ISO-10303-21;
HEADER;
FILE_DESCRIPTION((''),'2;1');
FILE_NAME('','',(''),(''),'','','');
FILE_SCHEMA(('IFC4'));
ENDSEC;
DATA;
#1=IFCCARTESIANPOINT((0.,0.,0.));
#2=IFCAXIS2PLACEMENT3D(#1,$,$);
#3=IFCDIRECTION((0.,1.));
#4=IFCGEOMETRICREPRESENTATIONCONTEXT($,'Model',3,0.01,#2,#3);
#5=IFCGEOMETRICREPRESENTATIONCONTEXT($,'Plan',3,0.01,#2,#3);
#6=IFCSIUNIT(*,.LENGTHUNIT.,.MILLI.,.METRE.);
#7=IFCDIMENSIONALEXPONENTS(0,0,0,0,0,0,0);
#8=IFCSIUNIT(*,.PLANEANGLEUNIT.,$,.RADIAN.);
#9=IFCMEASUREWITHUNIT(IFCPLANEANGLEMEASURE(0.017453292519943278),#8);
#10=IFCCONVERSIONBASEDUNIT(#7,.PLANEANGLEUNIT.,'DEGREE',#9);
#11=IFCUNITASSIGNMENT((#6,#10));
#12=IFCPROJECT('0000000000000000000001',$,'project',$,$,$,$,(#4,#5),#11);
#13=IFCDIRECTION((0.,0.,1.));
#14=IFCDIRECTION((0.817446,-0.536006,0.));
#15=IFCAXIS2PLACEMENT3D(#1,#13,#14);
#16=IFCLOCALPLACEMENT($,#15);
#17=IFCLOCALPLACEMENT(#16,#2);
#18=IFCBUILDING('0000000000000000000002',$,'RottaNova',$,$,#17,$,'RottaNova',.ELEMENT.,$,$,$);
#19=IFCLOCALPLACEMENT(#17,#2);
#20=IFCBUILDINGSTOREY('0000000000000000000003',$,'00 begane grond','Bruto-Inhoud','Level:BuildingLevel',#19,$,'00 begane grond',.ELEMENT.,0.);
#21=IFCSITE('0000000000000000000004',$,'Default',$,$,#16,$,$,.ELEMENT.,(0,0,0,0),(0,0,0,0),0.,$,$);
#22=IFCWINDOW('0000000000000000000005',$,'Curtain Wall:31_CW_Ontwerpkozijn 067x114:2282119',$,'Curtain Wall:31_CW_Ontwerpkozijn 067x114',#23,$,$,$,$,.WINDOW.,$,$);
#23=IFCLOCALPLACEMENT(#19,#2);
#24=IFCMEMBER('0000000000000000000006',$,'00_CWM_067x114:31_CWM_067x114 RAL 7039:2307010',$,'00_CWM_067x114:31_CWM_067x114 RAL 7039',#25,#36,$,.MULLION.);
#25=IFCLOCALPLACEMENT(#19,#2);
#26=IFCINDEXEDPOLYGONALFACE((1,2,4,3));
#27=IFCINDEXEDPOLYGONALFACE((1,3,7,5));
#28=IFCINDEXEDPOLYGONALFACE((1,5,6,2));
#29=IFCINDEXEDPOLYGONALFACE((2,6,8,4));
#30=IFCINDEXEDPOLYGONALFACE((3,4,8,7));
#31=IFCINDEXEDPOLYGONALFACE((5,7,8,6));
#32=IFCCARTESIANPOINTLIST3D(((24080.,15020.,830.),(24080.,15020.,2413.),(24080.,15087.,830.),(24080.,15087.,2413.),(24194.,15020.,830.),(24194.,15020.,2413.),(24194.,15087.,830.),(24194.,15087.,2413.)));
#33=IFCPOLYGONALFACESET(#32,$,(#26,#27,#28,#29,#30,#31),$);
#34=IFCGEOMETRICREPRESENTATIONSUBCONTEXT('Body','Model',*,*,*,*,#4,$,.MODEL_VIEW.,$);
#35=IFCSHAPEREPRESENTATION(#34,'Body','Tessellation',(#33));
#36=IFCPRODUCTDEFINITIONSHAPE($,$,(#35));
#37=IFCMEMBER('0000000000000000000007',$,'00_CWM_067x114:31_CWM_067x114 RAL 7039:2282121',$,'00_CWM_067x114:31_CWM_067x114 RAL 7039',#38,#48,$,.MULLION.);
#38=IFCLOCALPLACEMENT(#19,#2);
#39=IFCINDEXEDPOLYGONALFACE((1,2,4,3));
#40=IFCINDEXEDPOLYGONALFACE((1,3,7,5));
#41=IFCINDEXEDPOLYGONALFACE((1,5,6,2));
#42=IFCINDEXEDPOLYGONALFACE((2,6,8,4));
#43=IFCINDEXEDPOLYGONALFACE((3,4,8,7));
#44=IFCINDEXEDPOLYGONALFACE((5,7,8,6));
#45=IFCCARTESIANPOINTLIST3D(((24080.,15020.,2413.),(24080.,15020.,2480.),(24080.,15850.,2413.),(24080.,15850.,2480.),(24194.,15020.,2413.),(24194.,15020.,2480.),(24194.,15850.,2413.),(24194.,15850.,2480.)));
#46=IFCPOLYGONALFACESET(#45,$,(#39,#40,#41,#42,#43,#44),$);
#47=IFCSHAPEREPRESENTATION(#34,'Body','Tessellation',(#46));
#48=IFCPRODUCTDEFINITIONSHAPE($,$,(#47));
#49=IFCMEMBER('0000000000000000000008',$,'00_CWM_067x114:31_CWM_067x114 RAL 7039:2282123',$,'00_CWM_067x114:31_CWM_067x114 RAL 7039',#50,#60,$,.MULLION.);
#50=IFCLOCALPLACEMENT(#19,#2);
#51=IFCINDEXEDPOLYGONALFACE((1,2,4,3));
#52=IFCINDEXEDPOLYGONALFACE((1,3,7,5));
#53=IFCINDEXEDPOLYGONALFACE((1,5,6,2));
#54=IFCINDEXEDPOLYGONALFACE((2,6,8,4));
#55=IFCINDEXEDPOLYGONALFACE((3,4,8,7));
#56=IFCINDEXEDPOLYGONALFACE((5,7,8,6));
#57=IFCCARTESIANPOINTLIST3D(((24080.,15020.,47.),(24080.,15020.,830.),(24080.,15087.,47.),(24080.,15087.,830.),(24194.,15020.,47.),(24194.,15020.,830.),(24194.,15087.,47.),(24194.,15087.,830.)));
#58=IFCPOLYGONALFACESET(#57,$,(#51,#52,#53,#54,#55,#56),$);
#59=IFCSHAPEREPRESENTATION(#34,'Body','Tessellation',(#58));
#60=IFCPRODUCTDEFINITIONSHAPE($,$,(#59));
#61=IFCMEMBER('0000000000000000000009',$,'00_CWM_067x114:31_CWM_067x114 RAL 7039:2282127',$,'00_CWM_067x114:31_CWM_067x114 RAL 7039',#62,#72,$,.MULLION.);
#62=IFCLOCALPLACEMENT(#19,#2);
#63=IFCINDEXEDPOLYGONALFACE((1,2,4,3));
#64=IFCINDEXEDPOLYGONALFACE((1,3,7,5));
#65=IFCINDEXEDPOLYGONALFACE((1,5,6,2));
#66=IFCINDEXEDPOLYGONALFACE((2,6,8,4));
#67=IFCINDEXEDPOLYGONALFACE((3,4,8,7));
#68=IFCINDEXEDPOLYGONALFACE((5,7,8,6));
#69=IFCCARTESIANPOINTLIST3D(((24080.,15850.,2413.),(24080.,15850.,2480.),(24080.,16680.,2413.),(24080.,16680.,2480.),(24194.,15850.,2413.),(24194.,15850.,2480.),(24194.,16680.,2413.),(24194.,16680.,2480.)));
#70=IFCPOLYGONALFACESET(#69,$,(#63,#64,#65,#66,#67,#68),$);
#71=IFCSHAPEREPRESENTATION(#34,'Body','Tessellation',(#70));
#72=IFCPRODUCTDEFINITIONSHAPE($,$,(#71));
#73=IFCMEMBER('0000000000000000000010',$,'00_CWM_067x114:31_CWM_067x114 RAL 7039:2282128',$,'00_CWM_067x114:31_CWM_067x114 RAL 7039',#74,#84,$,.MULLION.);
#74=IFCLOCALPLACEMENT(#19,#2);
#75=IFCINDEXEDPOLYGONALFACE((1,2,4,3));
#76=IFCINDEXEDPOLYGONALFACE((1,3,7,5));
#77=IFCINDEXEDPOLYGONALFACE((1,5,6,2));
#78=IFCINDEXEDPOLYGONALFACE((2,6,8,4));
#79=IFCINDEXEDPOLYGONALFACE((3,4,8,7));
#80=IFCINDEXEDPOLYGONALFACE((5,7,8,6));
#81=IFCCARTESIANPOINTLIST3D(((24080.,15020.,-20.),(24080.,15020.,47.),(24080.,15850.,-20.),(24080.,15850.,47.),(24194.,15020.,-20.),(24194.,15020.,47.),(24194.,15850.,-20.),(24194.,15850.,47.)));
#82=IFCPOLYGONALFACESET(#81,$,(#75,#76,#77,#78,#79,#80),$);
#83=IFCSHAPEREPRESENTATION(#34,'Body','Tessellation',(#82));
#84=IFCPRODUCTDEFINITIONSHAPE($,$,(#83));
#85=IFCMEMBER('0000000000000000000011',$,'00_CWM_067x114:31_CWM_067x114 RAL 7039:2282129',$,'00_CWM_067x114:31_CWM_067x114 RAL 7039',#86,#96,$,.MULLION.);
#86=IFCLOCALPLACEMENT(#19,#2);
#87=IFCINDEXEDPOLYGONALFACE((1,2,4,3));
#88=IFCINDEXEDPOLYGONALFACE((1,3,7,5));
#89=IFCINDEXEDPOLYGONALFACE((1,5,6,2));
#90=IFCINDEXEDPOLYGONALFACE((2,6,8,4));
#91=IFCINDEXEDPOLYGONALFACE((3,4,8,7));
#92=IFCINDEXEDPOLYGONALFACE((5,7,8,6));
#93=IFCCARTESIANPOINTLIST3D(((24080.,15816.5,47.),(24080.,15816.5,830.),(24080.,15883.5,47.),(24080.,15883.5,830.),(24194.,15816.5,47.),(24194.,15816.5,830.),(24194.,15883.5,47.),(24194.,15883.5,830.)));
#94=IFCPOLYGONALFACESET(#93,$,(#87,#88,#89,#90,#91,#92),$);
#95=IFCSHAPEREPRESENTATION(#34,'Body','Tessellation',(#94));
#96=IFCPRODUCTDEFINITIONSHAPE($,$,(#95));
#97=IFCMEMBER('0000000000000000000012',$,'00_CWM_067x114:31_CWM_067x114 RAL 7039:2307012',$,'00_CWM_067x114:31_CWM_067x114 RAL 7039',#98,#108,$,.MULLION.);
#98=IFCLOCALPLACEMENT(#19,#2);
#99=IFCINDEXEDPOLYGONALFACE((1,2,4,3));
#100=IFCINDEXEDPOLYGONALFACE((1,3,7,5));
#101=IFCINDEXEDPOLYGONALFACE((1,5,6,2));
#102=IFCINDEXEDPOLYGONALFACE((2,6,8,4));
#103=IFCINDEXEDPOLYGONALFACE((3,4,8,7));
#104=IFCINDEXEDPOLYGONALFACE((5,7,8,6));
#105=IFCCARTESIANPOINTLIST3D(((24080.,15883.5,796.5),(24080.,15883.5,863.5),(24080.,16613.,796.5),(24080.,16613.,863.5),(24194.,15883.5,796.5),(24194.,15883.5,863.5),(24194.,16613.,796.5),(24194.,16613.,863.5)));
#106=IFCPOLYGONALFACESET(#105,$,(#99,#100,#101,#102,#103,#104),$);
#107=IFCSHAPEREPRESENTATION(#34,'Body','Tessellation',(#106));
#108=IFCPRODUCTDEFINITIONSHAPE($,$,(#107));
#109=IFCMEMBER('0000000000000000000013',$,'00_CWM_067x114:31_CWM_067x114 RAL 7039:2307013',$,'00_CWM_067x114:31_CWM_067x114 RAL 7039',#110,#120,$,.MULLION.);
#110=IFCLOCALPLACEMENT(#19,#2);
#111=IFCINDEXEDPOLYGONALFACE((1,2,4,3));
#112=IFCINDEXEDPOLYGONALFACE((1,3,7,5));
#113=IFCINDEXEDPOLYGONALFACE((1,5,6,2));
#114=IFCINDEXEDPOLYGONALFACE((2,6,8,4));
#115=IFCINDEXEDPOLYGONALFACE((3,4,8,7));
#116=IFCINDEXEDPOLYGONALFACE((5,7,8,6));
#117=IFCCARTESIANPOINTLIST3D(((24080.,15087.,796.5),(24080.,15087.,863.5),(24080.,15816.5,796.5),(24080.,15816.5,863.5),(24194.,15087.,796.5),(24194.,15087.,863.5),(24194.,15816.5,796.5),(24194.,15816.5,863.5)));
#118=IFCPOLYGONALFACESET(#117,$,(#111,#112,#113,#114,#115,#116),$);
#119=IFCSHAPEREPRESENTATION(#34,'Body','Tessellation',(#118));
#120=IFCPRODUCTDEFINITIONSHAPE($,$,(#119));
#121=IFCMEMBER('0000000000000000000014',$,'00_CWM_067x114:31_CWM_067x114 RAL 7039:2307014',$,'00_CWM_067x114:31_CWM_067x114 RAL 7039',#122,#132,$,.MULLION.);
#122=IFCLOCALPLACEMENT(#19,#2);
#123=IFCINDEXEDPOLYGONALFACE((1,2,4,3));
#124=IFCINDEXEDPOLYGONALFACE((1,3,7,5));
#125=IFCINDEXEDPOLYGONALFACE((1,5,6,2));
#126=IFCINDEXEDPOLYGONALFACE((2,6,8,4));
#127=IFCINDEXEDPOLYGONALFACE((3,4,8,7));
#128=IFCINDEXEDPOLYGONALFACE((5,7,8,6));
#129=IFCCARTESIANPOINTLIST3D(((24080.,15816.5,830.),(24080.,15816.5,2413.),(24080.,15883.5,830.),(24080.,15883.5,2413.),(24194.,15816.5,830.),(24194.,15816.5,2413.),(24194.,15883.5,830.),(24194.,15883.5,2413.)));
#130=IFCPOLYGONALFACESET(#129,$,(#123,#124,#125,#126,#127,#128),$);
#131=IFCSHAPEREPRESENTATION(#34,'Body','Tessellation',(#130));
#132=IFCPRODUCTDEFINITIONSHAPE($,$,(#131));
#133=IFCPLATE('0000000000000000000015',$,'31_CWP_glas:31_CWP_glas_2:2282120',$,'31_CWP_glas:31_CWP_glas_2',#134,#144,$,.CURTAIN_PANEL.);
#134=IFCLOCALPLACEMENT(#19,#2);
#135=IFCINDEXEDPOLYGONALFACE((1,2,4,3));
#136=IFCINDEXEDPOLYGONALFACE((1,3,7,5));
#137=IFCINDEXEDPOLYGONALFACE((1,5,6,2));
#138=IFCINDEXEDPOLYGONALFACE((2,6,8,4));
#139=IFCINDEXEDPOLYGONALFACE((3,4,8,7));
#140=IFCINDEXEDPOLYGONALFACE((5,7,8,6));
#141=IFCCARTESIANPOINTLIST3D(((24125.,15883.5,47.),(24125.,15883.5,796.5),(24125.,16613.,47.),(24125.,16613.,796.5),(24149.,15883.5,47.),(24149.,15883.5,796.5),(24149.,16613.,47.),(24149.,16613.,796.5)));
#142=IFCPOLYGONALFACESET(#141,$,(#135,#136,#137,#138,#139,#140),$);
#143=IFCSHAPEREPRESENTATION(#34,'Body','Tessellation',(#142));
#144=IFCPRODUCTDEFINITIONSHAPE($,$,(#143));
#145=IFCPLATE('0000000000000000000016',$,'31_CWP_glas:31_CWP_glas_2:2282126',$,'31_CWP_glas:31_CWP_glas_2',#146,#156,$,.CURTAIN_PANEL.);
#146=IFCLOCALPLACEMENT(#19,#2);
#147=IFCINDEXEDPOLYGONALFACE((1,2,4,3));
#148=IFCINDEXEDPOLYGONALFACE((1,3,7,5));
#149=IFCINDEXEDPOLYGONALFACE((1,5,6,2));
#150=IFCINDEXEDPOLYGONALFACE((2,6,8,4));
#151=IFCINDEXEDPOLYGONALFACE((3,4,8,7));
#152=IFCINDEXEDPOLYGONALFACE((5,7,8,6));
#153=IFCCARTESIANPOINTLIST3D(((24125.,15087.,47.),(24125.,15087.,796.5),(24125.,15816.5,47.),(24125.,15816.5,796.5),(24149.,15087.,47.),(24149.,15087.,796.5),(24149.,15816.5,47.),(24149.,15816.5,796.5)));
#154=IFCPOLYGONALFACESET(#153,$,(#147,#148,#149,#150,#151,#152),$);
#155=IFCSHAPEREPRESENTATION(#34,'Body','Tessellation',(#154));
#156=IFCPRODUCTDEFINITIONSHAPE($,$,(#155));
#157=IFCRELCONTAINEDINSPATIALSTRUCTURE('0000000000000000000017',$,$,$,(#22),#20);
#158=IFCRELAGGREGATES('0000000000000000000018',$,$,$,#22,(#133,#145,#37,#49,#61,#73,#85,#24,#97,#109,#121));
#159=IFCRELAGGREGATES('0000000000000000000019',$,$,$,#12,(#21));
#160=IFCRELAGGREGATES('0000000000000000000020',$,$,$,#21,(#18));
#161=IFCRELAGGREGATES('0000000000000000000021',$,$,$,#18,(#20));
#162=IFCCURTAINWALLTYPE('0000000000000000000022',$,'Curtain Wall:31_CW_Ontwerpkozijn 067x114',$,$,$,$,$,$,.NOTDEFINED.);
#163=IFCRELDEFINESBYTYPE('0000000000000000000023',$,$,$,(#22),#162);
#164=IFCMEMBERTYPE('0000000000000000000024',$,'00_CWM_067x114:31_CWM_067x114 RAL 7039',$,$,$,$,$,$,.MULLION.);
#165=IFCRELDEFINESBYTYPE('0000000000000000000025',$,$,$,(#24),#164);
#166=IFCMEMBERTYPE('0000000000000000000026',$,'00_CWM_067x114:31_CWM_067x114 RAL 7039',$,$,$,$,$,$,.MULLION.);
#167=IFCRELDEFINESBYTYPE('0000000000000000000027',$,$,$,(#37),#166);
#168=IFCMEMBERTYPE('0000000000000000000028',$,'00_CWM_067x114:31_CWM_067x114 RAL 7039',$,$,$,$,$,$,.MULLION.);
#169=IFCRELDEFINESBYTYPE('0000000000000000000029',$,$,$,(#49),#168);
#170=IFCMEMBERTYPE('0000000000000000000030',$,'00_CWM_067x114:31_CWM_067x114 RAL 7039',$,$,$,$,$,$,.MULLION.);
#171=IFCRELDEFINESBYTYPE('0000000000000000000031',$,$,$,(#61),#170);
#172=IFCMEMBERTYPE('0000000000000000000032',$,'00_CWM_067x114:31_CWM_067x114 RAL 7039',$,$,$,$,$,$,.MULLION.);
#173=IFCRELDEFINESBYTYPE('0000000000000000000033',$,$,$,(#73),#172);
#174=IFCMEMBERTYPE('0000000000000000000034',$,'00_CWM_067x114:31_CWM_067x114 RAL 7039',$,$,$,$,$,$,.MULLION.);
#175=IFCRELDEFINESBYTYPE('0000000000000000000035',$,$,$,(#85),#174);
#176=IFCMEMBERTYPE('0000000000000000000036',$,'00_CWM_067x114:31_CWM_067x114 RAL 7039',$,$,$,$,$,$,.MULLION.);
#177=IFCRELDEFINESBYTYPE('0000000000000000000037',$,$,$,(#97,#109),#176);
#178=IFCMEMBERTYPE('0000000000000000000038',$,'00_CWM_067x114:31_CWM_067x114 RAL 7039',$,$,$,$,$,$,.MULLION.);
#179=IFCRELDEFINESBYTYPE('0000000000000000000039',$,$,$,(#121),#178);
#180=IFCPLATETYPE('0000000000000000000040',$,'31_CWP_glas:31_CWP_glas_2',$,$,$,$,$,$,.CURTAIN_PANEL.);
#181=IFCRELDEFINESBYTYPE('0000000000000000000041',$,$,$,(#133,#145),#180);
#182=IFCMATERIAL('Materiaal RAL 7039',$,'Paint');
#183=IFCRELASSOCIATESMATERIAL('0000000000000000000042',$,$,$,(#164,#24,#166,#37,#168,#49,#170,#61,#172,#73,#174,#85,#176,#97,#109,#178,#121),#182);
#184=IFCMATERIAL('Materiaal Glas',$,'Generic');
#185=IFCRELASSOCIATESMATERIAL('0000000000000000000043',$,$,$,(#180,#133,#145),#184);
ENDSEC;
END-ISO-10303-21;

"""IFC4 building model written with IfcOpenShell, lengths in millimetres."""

from ifc_helpers import new_model, entity, si_unit, converted_unit, direction, frame, origin, place, context, subcontext, project, spatial, indexed_curve, outline, extrude, source, transform, mapped, material, type_object, type_shapes, element, aggregate, save


model = new_model("IFC4")

# Units and contexts
model_context = context("Model", 3, precision=0.01, world=origin(), true_north=direction((0.0, 1.0)))
plan_context = context("Plan", 3, precision=0.01, world=origin(), true_north=direction((0.0, 1.0)))
body_context = subcontext(model_context, "Body", "Model", "MODEL_VIEW")
ifc_project = project(units=[si_unit("LENGTHUNIT", "METRE", prefix="MILLI"), converted_unit("PLANEANGLEUNIT", "DEGREE", entity("IfcPlaneAngleMeasure", 0.017453292519943278), si_unit("PLANEANGLEUNIT", "RADIAN"), dimensions=[0, 0, 0, 0, 0, 0, 0])], contexts=[model_context, plan_context])

# Site, building, storey
site_placement = place(None, frame((0.0, 0.0, 0.0), z_axis=(0.0, 0.0, 1.0), x_axis=(0.817446, -0.536006, 0.0)))
site = spatial("IfcSite", under=ifc_project, at=site_placement, Name="Default", CompositionType="ELEMENT", RefLatitude=(0, 0, 0, 0), RefLongitude=(0, 0, 0, 0), RefElevation=0.0)
building_placement = place(site_placement, origin())
building = spatial("IfcBuilding", under=site, at=building_placement, Name="RottaNova", LongName="RottaNova", CompositionType="ELEMENT")
storey_placement = place(building_placement, origin())
storey = spatial("IfcBuildingStorey", under=building, at=storey_placement, Name="00 begane grond", Description="Bruto-Inhoud", ObjectType="Level:BuildingLevel", LongName="00 begane grond", CompositionType="ELEMENT", Elevation=0.0)

# Window, members, plates
curtain_wall_type = type_object("IfcCurtainWallType", Name="Curtain Wall:31_CW_Ontwerpkozijn 067x114", PredefinedType="NOTDEFINED")
window_placement = place(storey_placement, origin())
window = element("IfcWindow", 1, at=window_placement, inside=storey, type_object=curtain_wall_type, Name="Curtain Wall:31_CW_Ontwerpkozijn 067x114:2282119", ObjectType="Curtain Wall:31_CW_Ontwerpkozijn 067x114", PredefinedType="WINDOW")
ifc_material_1 = material(Name="Materiaal RAL 7039", Category="Paint")
member_type_1 = type_object("IfcMemberType", Name="00_CWM_067x114:31_CWM_067x114 RAL 7039", PredefinedType="MULLION", material=ifc_material_1)
shared_shape_1 = source(origin(), body_context, "Body", "SweptSolid", [
    extrude(outline(indexed_curve([(-33.5, -57.0), (33.5, -57.0), (33.5, 57.0), (-33.5, 57.0), (-33.5, -57.0)], self_intersect=False)), frame((-33.5, -57.0, -1583.0), z_axis=(0.0, 0.0, 1.0), x_axis=(-1.0, 0.0, 0.0)), (0.0, 0.0, 1.0), 1583.0),
])
type_shapes(member_type_1, [shared_shape_1])
member_1_placement = place(window_placement, frame((24080.0, 15020.0, 830.0), z_axis=(0.0, 0.0, -1.0), x_axis=(0.0, -1.0, 0.0)))
member_1 = element("IfcMember", 2, at=member_1_placement, type_object=member_type_1, material=ifc_material_1, Name="00_CWM_067x114:31_CWM_067x114 RAL 7039:2307010", ObjectType="00_CWM_067x114:31_CWM_067x114 RAL 7039", PredefinedType="MULLION", context=body_context, shape_type="MappedRepresentation", body=[
    mapped(shared_shape_1, transform((0.0, 0.0, 0.0), scale=1.0)),
])
member_type_2 = type_object("IfcMemberType", Name="00_CWM_067x114:31_CWM_067x114 RAL 7039", PredefinedType="MULLION", material=ifc_material_1)
shared_shape_2 = source(origin(), body_context, "Body", "SweptSolid", [
    extrude(outline(indexed_curve([(-33.5, -57.0), (33.5, -57.0), (33.5, 57.0), (-33.5, 57.0), (-33.5, -57.0)], self_intersect=False)), frame((-33.5, -57.0, -830.0), z_axis=(0.0, 0.0, 1.0), x_axis=(-1.0, 0.0, 0.0)), (0.0, 0.0, 1.0), 830.0),
])
type_shapes(member_type_2, [shared_shape_2])
member_2_placement = place(window_placement, frame((24080.0, 15020.0, 2480.0), z_axis=(0.0, -1.0, 0.0), x_axis=(0.0, 0.0, 1.0)))
member_2 = element("IfcMember", 3, at=member_2_placement, type_object=member_type_2, material=ifc_material_1, Name="00_CWM_067x114:31_CWM_067x114 RAL 7039:2282121", ObjectType="00_CWM_067x114:31_CWM_067x114 RAL 7039", PredefinedType="MULLION", context=body_context, shape_type="MappedRepresentation", body=[
    mapped(shared_shape_2, transform((0.0, 0.0, 0.0), scale=1.0)),
])
member_type_3 = type_object("IfcMemberType", Name="00_CWM_067x114:31_CWM_067x114 RAL 7039", PredefinedType="MULLION", material=ifc_material_1)
shared_shape_3 = source(origin(), body_context, "Body", "SweptSolid", [
    extrude(outline(indexed_curve([(-33.5, -57.0), (33.5, -57.0), (33.5, 57.0), (-33.5, 57.0), (-33.5, -57.0)], self_intersect=False)), frame((-33.5, -57.0, -783.0), z_axis=(0.0, 0.0, 1.0), x_axis=(-1.0, 0.0, 0.0)), (0.0, 0.0, 1.0), 783.0),
])
type_shapes(member_type_3, [shared_shape_3])
member_3_placement = place(window_placement, frame((24080.0, 15020.0, 47.0), z_axis=(0.0, 0.0, -1.0), x_axis=(0.0, -1.0, 0.0)))
member_3 = element("IfcMember", 4, at=member_3_placement, type_object=member_type_3, material=ifc_material_1, Name="00_CWM_067x114:31_CWM_067x114 RAL 7039:2282123", ObjectType="00_CWM_067x114:31_CWM_067x114 RAL 7039", PredefinedType="MULLION", context=body_context, shape_type="MappedRepresentation", body=[
    mapped(shared_shape_3, transform((0.0, 0.0, 0.0), scale=1.0)),
])
member_type_4 = type_object("IfcMemberType", Name="00_CWM_067x114:31_CWM_067x114 RAL 7039", PredefinedType="MULLION", material=ifc_material_1)
shared_shape_4 = source(origin(), body_context, "Body", "SweptSolid", [
    extrude(outline(indexed_curve([(-33.5, -57.0), (33.5, -57.0), (33.5, 57.0), (-33.5, 57.0), (-33.5, -57.0)], self_intersect=False)), frame((-33.5, -57.0, -830.0), z_axis=(0.0, 0.0, 1.0), x_axis=(-1.0, 0.0, 0.0)), (0.0, 0.0, 1.0), 830.0),
])
type_shapes(member_type_4, [shared_shape_4])
member_4_placement = place(window_placement, frame((24080.0, 15850.0, 2480.0), z_axis=(0.0, -1.0, 0.0), x_axis=(0.0, 0.0, 1.0)))
member_4 = element("IfcMember", 5, at=member_4_placement, type_object=member_type_4, material=ifc_material_1, Name="00_CWM_067x114:31_CWM_067x114 RAL 7039:2282127", ObjectType="00_CWM_067x114:31_CWM_067x114 RAL 7039", PredefinedType="MULLION", context=body_context, shape_type="MappedRepresentation", body=[
    mapped(shared_shape_4, transform((0.0, 0.0, 0.0), scale=1.0)),
])
member_type_5 = type_object("IfcMemberType", Name="00_CWM_067x114:31_CWM_067x114 RAL 7039", PredefinedType="MULLION", material=ifc_material_1)
shared_shape_5 = source(origin(), body_context, "Body", "SweptSolid", [
    extrude(outline(indexed_curve([(-33.5, -57.0), (33.5, -57.0), (33.5, 57.0), (-33.5, 57.0), (-33.5, -57.0)], self_intersect=False)), frame((-33.5, -57.0, -830.0), z_axis=(0.0, 0.0, 1.0), x_axis=(-1.0, 0.0, 0.0)), (0.0, 0.0, 1.0), 830.0),
])
type_shapes(member_type_5, [shared_shape_5])
member_5_placement = place(window_placement, frame((24080.0, 15850.0, -20.0), z_axis=(0.0, 1.0, 0.0), x_axis=(0.0, 0.0, -1.0)))
member_5 = element("IfcMember", 6, at=member_5_placement, type_object=member_type_5, material=ifc_material_1, Name="00_CWM_067x114:31_CWM_067x114 RAL 7039:2282128", ObjectType="00_CWM_067x114:31_CWM_067x114 RAL 7039", PredefinedType="MULLION", context=body_context, shape_type="MappedRepresentation", body=[
    mapped(shared_shape_5, transform((0.0, 0.0, 0.0), scale=1.0)),
])
member_type_6 = type_object("IfcMemberType", Name="00_CWM_067x114:31_CWM_067x114 RAL 7039", PredefinedType="MULLION", material=ifc_material_1)
shared_shape_6 = source(origin(), body_context, "Body", "SweptSolid", [
    extrude(outline(indexed_curve([(-33.5, -57.0), (33.5, -57.0), (33.5, 57.0), (-33.5, 57.0), (-33.5, -57.0)], self_intersect=False)), frame((0.0, -57.0, -783.0), z_axis=(0.0, 0.0, 1.0), x_axis=(-1.0, 0.0, 0.0)), (0.0, 0.0, 1.0), 783.0),
])
type_shapes(member_type_6, [shared_shape_6])
member_6_placement = place(window_placement, frame((24080.0, 15850.0, 47.0), z_axis=(0.0, 0.0, -1.0), x_axis=(0.0, -1.0, 0.0)))
member_6 = element("IfcMember", 7, at=member_6_placement, type_object=member_type_6, material=ifc_material_1, Name="00_CWM_067x114:31_CWM_067x114 RAL 7039:2282129", ObjectType="00_CWM_067x114:31_CWM_067x114 RAL 7039", PredefinedType="MULLION", context=body_context, shape_type="MappedRepresentation", body=[
    mapped(shared_shape_6, transform((0.0, 0.0, 0.0), scale=1.0)),
])
member_type_7 = type_object("IfcMemberType", Name="00_CWM_067x114:31_CWM_067x114 RAL 7039", PredefinedType="MULLION", material=ifc_material_1)
shared_shape_7 = source(origin(), body_context, "Body", "SweptSolid", [
    extrude(outline(indexed_curve([(-33.5, -57.0), (33.5, -57.0), (33.5, 57.0), (-33.5, 57.0), (-33.5, -57.0)], self_intersect=False)), frame((0.0, -57.0, -729.5), z_axis=(0.0, 0.0, 1.0), x_axis=(-1.0, 0.0, 0.0)), (0.0, 0.0, 1.0), 729.5),
])
type_shapes(member_type_7, [shared_shape_7])
member_7_placement = place(window_placement, frame((24080.0, 15883.5, 830.0), z_axis=(0.0, -1.0, 0.0), x_axis=(0.0, 0.0, 1.0)))
member_7 = element("IfcMember", 8, at=member_7_placement, type_object=member_type_7, material=ifc_material_1, Name="00_CWM_067x114:31_CWM_067x114 RAL 7039:2307012", ObjectType="00_CWM_067x114:31_CWM_067x114 RAL 7039", PredefinedType="MULLION", context=body_context, shape_type="MappedRepresentation", body=[
    mapped(shared_shape_7, transform((0.0, 0.0, 0.0), scale=1.0)),
])
member_8_placement = place(window_placement, frame((24080.0, 15087.0, 830.0), z_axis=(0.0, -1.0, 0.0), x_axis=(0.0, 0.0, 1.0)))
member_8 = element("IfcMember", 9, at=member_8_placement, type_object=member_type_7, material=ifc_material_1, Name="00_CWM_067x114:31_CWM_067x114 RAL 7039:2307013", ObjectType="00_CWM_067x114:31_CWM_067x114 RAL 7039", PredefinedType="MULLION", context=body_context, shape_type="MappedRepresentation", body=[
    mapped(shared_shape_7, transform((0.0, 0.0, 0.0), scale=1.0)),
])
member_type_8 = type_object("IfcMemberType", Name="00_CWM_067x114:31_CWM_067x114 RAL 7039", PredefinedType="MULLION", material=ifc_material_1)
shared_shape_8 = source(origin(), body_context, "Body", "SweptSolid", [
    extrude(outline(indexed_curve([(-33.5, -57.0), (33.5, -57.0), (33.5, 57.0), (-33.5, 57.0), (-33.5, -57.0)], self_intersect=False)), frame((0.0, -57.0, -1583.0), z_axis=(0.0, 0.0, 1.0), x_axis=(-1.0, 0.0, 0.0)), (0.0, 0.0, 1.0), 1583.0),
])
type_shapes(member_type_8, [shared_shape_8])
member_9_placement = place(window_placement, frame((24080.0, 15850.0, 830.0), z_axis=(0.0, 0.0, -1.0), x_axis=(0.0, -1.0, 0.0)))
member_9 = element("IfcMember", 10, at=member_9_placement, type_object=member_type_8, material=ifc_material_1, Name="00_CWM_067x114:31_CWM_067x114 RAL 7039:2307014", ObjectType="00_CWM_067x114:31_CWM_067x114 RAL 7039", PredefinedType="MULLION", context=body_context, shape_type="MappedRepresentation", body=[
    mapped(shared_shape_8, transform((0.0, 0.0, 0.0), scale=1.0)),
])
ifc_material_2 = material(Name="Materiaal Glas", Category="Generic")
plate_type_1 = type_object("IfcPlateType", Name="31_CWP_glas:31_CWP_glas_2", PredefinedType="CURTAIN_PANEL", material=ifc_material_2)
shared_shape_9 = source(origin(), body_context, "Body", "SweptSolid", [
    extrude(outline(indexed_curve([(-12.0, -364.7), (12.0, -364.7), (12.0, 364.7), (-12.0, 364.7), (-12.0, -364.7)], self_intersect=False)), frame((0.0, 57.0, 0.0), z_axis=(0.0, 0.0, 1.0), x_axis=(0.0, 1.0, 0.0)), (0.0, 0.0, 1.0), 749.5),
])
type_shapes(plate_type_1, [shared_shape_9])
plate_1_placement = place(window_placement, frame((24080.0, 16248.3, 47.0), z_axis=(0.0, 0.0, 1.0), x_axis=(0.0, -1.0, 0.0)))
plate_1 = element("IfcPlate", 11, at=plate_1_placement, type_object=plate_type_1, material=ifc_material_2, Name="31_CWP_glas:31_CWP_glas_2:2282120", ObjectType="31_CWP_glas:31_CWP_glas_2", PredefinedType="CURTAIN_PANEL", context=body_context, shape_type="MappedRepresentation", body=[
    mapped(shared_shape_9, transform((0.0, 0.0, 0.0), scale=1.0)),
])
plate_2_placement = place(window_placement, frame((24080.0, 15451.8, 47.0), z_axis=(0.0, 0.0, 1.0), x_axis=(0.0, -1.0, 0.0)))
plate_2 = element("IfcPlate", 12, at=plate_2_placement, type_object=plate_type_1, material=ifc_material_2, Name="31_CWP_glas:31_CWP_glas_2:2282126", ObjectType="31_CWP_glas:31_CWP_glas_2", PredefinedType="CURTAIN_PANEL", context=body_context, shape_type="MappedRepresentation", body=[
    mapped(shared_shape_9, transform((0.0, 0.0, 0.0), scale=1.0)),
])
aggregate(window, [plate_1, plate_2, member_2, member_3, member_4, member_5, member_6, member_1, member_7, member_8, member_9])

save(model, "model.ifc")
